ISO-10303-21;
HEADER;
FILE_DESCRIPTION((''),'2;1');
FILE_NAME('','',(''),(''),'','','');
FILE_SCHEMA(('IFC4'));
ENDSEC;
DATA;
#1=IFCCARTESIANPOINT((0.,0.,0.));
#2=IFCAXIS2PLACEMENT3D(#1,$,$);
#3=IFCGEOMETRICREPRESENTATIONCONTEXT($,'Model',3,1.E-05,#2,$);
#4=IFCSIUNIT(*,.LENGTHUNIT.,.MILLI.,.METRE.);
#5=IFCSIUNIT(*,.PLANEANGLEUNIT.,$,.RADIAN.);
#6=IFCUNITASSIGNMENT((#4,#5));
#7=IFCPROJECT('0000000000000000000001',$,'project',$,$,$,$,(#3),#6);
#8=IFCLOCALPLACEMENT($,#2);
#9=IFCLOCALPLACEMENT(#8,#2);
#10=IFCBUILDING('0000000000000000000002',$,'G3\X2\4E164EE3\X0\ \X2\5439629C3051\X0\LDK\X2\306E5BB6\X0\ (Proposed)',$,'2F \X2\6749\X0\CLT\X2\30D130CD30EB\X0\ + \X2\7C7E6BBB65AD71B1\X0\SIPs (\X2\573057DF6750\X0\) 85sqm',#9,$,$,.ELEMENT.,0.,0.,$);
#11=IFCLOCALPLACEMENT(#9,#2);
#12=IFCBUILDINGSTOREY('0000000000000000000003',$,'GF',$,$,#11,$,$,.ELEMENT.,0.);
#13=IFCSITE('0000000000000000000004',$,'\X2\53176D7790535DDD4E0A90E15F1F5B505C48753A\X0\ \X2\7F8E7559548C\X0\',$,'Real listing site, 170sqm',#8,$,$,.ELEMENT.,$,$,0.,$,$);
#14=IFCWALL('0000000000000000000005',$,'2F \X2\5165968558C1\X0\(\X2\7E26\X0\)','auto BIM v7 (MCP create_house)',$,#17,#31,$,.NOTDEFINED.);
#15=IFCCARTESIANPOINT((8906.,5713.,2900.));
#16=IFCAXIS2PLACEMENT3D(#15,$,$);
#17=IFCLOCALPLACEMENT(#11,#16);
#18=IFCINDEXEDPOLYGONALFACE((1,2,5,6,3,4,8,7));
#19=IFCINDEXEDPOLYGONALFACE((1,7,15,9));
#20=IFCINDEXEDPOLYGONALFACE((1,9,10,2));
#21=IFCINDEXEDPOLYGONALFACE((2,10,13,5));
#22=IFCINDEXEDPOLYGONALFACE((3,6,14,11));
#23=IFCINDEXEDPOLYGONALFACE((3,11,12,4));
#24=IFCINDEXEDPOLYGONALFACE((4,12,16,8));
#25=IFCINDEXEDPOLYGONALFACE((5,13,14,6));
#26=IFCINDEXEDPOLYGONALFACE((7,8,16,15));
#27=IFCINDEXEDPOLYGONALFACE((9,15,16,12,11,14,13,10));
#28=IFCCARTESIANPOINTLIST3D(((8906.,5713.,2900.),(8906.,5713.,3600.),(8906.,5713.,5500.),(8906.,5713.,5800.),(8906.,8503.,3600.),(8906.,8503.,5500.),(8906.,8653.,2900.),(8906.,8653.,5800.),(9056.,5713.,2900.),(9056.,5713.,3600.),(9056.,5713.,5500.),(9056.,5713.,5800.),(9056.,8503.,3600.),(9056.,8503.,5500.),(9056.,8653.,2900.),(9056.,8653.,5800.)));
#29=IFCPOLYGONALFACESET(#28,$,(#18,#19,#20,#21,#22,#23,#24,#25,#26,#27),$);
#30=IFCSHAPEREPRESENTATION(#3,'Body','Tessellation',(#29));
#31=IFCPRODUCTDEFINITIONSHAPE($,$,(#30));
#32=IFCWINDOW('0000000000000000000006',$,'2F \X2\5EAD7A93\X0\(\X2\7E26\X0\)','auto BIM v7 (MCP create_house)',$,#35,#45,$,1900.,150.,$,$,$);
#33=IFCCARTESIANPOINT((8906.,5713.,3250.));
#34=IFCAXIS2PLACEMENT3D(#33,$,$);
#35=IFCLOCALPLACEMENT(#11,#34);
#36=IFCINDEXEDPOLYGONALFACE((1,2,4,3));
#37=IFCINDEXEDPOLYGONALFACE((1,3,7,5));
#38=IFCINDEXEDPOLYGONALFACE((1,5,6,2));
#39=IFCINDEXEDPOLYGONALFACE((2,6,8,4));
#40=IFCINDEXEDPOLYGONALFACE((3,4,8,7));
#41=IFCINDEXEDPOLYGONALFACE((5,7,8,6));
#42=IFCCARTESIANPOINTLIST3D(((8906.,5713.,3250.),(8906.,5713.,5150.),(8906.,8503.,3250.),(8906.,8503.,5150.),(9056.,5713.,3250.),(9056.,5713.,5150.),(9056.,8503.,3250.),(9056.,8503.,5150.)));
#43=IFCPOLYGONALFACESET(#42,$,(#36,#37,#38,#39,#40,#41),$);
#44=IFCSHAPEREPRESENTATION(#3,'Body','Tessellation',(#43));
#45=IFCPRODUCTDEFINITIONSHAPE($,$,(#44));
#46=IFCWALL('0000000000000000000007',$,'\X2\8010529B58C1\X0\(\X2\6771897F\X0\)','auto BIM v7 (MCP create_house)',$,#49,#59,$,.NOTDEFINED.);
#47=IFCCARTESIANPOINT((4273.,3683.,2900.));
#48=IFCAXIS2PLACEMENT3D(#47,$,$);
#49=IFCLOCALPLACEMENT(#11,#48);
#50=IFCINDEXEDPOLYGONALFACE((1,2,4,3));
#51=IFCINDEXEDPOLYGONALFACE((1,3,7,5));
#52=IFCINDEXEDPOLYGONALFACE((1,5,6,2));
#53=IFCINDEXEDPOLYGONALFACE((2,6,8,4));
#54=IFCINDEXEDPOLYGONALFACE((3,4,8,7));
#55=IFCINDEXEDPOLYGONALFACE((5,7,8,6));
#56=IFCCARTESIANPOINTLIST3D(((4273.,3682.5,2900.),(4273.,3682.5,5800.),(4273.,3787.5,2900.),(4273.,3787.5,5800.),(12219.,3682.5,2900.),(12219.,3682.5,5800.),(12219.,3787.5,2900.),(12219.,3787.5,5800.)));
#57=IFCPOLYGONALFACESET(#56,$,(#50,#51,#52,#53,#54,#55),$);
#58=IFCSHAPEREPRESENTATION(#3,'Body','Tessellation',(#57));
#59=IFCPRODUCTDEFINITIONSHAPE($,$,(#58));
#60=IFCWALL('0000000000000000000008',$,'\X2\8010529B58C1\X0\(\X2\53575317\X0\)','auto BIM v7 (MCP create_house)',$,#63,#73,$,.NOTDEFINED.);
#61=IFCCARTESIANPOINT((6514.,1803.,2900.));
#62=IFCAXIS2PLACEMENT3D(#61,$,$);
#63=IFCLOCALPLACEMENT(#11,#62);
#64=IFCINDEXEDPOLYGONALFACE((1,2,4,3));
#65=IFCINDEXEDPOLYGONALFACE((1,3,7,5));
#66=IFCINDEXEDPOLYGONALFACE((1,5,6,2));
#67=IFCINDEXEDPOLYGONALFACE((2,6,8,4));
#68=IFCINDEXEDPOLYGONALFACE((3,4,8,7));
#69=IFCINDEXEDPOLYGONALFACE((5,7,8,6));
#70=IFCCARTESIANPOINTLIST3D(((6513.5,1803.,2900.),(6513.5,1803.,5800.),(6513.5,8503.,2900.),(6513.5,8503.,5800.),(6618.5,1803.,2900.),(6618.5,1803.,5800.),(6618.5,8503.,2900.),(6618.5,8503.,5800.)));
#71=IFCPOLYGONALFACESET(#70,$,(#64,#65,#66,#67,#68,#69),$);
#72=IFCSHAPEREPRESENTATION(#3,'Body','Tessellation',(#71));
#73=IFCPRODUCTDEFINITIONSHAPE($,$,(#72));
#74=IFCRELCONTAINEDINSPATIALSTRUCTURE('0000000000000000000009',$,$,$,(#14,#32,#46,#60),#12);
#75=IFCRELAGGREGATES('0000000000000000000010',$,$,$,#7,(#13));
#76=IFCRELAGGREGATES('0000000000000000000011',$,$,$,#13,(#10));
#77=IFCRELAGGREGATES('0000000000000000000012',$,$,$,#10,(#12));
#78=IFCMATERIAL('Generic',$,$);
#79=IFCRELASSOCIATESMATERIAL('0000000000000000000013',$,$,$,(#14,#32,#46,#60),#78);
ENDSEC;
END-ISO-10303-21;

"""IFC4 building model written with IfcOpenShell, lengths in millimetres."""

from ifc_helpers import new_model, si_unit, frame, frame_2d, origin, place, context, project, spatial, rectangle, extrude, material, element, fill, save


model = new_model("IFC4")

# Units and contexts
model_context = context("Model", 3, precision=1e-05, world=origin())
ifc_project = project(units=[si_unit("LENGTHUNIT", "METRE", prefix="MILLI"), si_unit("PLANEANGLEUNIT", "RADIAN")], contexts=[model_context])

# Site, building, storey
site_placement = place(None, origin())
site = spatial("IfcSite", under=ifc_project, at=site_placement, Name="北海道川上郡弟子屈町 美留和", ObjectType="Real listing site, 170sqm", CompositionType="ELEMENT", RefElevation=0.0)
building_placement = place(site_placement, origin())
building = spatial("IfcBuilding", under=site, at=building_placement, Name="G3世代 吹抜けLDKの家 (Proposed)", ObjectType="2F 杉CLTパネル + 籾殻断熱SIPs (地域材) 85sqm", CompositionType="ELEMENT", ElevationOfRefHeight=0.0, ElevationOfTerrain=0.0)
storey_placement = place(building_placement, origin())
storey = spatial("IfcBuildingStorey", under=building, at=storey_placement, Name="GF", CompositionType="ELEMENT", Elevation=0.0)

# Shared definitions
ifc_material = material(Name="Generic")

# Wall, opening, window
wall_1_placement = place(storey_placement, frame((8906.0, 5713.0, 2900.0)))
wall_1 = element("IfcWall", 1, at=wall_1_placement, inside=storey, material=ifc_material, Name="2F 入隅壁(縦)", Description="auto BIM v7 (MCP create_house)", PredefinedType="NOTDEFINED", context=model_context, shape_type="SweptSolid", body=[
    extrude(rectangle(XDim=150.0, YDim=2940.0, at=frame_2d((75.0, 1470.0))), frame((8906.0, 5713.0, 2900.0)), (0.0, 0.0, 1.0), 2900.0),
])
opening_1_placement = place(storey_placement, frame((8906.0, 5713.0, 3250.0)))
opening_1 = element("IfcOpeningElement", 2, at=opening_1_placement, cuts=wall_1, PredefinedType="NOTDEFINED", context=model_context, shape_type="SweptSolid", body=[
    extrude(rectangle(XDim=150.0, YDim=2790.0, at=frame_2d((75.0, 1395.0))), frame((8906.0, 5713.0, 3250.0)), (0.0, 0.0, 1.0), 1900.0),
])
window_1_placement = place(storey_placement, frame((8906.0, 5713.0, 3250.0)))
window_1 = element("IfcWindow", 3, at=window_1_placement, inside=storey, material=ifc_material, Name="2F 庭窓(縦)", Description="auto BIM v7 (MCP create_house)", OverallHeight=1900.0, OverallWidth=150.0, context=model_context, shape_type="SweptSolid", body=[
    extrude(rectangle(XDim=150.0, YDim=2790.0, at=frame_2d((75.0, 1395.0))), frame((8906.0, 5713.0, 3250.0)), (0.0, 0.0, 1.0), 1900.0),
])
fill(opening_1, window_1)

# Walls
wall_2_placement = place(storey_placement, frame((4273.0, 3683.0, 2900.0)))
element("IfcWall", 4, at=wall_2_placement, inside=storey, material=ifc_material, Name="耐力壁(東西)", Description="auto BIM v7 (MCP create_house)", PredefinedType="NOTDEFINED", context=model_context, shape_type="SweptSolid", body=[
    extrude(rectangle(XDim=7946.0, YDim=105.0, at=frame_2d((3973.0, 52.0))), frame((4273.0, 3683.0, 2900.0)), (0.0, 0.0, 1.0), 2900.0),
])
wall_3_placement = place(storey_placement, frame((6514.0, 1803.0, 2900.0)))
element("IfcWall", 5, at=wall_3_placement, inside=storey, material=ifc_material, Name="耐力壁(南北)", Description="auto BIM v7 (MCP create_house)", PredefinedType="NOTDEFINED", context=model_context, shape_type="SweptSolid", body=[
    extrude(rectangle(XDim=105.0, YDim=6700.0, at=frame_2d((52.0, 3350.0))), frame((6514.0, 1803.0, 2900.0)), (0.0, 0.0, 1.0), 2900.0),
])

save(model, "model.ifc")
